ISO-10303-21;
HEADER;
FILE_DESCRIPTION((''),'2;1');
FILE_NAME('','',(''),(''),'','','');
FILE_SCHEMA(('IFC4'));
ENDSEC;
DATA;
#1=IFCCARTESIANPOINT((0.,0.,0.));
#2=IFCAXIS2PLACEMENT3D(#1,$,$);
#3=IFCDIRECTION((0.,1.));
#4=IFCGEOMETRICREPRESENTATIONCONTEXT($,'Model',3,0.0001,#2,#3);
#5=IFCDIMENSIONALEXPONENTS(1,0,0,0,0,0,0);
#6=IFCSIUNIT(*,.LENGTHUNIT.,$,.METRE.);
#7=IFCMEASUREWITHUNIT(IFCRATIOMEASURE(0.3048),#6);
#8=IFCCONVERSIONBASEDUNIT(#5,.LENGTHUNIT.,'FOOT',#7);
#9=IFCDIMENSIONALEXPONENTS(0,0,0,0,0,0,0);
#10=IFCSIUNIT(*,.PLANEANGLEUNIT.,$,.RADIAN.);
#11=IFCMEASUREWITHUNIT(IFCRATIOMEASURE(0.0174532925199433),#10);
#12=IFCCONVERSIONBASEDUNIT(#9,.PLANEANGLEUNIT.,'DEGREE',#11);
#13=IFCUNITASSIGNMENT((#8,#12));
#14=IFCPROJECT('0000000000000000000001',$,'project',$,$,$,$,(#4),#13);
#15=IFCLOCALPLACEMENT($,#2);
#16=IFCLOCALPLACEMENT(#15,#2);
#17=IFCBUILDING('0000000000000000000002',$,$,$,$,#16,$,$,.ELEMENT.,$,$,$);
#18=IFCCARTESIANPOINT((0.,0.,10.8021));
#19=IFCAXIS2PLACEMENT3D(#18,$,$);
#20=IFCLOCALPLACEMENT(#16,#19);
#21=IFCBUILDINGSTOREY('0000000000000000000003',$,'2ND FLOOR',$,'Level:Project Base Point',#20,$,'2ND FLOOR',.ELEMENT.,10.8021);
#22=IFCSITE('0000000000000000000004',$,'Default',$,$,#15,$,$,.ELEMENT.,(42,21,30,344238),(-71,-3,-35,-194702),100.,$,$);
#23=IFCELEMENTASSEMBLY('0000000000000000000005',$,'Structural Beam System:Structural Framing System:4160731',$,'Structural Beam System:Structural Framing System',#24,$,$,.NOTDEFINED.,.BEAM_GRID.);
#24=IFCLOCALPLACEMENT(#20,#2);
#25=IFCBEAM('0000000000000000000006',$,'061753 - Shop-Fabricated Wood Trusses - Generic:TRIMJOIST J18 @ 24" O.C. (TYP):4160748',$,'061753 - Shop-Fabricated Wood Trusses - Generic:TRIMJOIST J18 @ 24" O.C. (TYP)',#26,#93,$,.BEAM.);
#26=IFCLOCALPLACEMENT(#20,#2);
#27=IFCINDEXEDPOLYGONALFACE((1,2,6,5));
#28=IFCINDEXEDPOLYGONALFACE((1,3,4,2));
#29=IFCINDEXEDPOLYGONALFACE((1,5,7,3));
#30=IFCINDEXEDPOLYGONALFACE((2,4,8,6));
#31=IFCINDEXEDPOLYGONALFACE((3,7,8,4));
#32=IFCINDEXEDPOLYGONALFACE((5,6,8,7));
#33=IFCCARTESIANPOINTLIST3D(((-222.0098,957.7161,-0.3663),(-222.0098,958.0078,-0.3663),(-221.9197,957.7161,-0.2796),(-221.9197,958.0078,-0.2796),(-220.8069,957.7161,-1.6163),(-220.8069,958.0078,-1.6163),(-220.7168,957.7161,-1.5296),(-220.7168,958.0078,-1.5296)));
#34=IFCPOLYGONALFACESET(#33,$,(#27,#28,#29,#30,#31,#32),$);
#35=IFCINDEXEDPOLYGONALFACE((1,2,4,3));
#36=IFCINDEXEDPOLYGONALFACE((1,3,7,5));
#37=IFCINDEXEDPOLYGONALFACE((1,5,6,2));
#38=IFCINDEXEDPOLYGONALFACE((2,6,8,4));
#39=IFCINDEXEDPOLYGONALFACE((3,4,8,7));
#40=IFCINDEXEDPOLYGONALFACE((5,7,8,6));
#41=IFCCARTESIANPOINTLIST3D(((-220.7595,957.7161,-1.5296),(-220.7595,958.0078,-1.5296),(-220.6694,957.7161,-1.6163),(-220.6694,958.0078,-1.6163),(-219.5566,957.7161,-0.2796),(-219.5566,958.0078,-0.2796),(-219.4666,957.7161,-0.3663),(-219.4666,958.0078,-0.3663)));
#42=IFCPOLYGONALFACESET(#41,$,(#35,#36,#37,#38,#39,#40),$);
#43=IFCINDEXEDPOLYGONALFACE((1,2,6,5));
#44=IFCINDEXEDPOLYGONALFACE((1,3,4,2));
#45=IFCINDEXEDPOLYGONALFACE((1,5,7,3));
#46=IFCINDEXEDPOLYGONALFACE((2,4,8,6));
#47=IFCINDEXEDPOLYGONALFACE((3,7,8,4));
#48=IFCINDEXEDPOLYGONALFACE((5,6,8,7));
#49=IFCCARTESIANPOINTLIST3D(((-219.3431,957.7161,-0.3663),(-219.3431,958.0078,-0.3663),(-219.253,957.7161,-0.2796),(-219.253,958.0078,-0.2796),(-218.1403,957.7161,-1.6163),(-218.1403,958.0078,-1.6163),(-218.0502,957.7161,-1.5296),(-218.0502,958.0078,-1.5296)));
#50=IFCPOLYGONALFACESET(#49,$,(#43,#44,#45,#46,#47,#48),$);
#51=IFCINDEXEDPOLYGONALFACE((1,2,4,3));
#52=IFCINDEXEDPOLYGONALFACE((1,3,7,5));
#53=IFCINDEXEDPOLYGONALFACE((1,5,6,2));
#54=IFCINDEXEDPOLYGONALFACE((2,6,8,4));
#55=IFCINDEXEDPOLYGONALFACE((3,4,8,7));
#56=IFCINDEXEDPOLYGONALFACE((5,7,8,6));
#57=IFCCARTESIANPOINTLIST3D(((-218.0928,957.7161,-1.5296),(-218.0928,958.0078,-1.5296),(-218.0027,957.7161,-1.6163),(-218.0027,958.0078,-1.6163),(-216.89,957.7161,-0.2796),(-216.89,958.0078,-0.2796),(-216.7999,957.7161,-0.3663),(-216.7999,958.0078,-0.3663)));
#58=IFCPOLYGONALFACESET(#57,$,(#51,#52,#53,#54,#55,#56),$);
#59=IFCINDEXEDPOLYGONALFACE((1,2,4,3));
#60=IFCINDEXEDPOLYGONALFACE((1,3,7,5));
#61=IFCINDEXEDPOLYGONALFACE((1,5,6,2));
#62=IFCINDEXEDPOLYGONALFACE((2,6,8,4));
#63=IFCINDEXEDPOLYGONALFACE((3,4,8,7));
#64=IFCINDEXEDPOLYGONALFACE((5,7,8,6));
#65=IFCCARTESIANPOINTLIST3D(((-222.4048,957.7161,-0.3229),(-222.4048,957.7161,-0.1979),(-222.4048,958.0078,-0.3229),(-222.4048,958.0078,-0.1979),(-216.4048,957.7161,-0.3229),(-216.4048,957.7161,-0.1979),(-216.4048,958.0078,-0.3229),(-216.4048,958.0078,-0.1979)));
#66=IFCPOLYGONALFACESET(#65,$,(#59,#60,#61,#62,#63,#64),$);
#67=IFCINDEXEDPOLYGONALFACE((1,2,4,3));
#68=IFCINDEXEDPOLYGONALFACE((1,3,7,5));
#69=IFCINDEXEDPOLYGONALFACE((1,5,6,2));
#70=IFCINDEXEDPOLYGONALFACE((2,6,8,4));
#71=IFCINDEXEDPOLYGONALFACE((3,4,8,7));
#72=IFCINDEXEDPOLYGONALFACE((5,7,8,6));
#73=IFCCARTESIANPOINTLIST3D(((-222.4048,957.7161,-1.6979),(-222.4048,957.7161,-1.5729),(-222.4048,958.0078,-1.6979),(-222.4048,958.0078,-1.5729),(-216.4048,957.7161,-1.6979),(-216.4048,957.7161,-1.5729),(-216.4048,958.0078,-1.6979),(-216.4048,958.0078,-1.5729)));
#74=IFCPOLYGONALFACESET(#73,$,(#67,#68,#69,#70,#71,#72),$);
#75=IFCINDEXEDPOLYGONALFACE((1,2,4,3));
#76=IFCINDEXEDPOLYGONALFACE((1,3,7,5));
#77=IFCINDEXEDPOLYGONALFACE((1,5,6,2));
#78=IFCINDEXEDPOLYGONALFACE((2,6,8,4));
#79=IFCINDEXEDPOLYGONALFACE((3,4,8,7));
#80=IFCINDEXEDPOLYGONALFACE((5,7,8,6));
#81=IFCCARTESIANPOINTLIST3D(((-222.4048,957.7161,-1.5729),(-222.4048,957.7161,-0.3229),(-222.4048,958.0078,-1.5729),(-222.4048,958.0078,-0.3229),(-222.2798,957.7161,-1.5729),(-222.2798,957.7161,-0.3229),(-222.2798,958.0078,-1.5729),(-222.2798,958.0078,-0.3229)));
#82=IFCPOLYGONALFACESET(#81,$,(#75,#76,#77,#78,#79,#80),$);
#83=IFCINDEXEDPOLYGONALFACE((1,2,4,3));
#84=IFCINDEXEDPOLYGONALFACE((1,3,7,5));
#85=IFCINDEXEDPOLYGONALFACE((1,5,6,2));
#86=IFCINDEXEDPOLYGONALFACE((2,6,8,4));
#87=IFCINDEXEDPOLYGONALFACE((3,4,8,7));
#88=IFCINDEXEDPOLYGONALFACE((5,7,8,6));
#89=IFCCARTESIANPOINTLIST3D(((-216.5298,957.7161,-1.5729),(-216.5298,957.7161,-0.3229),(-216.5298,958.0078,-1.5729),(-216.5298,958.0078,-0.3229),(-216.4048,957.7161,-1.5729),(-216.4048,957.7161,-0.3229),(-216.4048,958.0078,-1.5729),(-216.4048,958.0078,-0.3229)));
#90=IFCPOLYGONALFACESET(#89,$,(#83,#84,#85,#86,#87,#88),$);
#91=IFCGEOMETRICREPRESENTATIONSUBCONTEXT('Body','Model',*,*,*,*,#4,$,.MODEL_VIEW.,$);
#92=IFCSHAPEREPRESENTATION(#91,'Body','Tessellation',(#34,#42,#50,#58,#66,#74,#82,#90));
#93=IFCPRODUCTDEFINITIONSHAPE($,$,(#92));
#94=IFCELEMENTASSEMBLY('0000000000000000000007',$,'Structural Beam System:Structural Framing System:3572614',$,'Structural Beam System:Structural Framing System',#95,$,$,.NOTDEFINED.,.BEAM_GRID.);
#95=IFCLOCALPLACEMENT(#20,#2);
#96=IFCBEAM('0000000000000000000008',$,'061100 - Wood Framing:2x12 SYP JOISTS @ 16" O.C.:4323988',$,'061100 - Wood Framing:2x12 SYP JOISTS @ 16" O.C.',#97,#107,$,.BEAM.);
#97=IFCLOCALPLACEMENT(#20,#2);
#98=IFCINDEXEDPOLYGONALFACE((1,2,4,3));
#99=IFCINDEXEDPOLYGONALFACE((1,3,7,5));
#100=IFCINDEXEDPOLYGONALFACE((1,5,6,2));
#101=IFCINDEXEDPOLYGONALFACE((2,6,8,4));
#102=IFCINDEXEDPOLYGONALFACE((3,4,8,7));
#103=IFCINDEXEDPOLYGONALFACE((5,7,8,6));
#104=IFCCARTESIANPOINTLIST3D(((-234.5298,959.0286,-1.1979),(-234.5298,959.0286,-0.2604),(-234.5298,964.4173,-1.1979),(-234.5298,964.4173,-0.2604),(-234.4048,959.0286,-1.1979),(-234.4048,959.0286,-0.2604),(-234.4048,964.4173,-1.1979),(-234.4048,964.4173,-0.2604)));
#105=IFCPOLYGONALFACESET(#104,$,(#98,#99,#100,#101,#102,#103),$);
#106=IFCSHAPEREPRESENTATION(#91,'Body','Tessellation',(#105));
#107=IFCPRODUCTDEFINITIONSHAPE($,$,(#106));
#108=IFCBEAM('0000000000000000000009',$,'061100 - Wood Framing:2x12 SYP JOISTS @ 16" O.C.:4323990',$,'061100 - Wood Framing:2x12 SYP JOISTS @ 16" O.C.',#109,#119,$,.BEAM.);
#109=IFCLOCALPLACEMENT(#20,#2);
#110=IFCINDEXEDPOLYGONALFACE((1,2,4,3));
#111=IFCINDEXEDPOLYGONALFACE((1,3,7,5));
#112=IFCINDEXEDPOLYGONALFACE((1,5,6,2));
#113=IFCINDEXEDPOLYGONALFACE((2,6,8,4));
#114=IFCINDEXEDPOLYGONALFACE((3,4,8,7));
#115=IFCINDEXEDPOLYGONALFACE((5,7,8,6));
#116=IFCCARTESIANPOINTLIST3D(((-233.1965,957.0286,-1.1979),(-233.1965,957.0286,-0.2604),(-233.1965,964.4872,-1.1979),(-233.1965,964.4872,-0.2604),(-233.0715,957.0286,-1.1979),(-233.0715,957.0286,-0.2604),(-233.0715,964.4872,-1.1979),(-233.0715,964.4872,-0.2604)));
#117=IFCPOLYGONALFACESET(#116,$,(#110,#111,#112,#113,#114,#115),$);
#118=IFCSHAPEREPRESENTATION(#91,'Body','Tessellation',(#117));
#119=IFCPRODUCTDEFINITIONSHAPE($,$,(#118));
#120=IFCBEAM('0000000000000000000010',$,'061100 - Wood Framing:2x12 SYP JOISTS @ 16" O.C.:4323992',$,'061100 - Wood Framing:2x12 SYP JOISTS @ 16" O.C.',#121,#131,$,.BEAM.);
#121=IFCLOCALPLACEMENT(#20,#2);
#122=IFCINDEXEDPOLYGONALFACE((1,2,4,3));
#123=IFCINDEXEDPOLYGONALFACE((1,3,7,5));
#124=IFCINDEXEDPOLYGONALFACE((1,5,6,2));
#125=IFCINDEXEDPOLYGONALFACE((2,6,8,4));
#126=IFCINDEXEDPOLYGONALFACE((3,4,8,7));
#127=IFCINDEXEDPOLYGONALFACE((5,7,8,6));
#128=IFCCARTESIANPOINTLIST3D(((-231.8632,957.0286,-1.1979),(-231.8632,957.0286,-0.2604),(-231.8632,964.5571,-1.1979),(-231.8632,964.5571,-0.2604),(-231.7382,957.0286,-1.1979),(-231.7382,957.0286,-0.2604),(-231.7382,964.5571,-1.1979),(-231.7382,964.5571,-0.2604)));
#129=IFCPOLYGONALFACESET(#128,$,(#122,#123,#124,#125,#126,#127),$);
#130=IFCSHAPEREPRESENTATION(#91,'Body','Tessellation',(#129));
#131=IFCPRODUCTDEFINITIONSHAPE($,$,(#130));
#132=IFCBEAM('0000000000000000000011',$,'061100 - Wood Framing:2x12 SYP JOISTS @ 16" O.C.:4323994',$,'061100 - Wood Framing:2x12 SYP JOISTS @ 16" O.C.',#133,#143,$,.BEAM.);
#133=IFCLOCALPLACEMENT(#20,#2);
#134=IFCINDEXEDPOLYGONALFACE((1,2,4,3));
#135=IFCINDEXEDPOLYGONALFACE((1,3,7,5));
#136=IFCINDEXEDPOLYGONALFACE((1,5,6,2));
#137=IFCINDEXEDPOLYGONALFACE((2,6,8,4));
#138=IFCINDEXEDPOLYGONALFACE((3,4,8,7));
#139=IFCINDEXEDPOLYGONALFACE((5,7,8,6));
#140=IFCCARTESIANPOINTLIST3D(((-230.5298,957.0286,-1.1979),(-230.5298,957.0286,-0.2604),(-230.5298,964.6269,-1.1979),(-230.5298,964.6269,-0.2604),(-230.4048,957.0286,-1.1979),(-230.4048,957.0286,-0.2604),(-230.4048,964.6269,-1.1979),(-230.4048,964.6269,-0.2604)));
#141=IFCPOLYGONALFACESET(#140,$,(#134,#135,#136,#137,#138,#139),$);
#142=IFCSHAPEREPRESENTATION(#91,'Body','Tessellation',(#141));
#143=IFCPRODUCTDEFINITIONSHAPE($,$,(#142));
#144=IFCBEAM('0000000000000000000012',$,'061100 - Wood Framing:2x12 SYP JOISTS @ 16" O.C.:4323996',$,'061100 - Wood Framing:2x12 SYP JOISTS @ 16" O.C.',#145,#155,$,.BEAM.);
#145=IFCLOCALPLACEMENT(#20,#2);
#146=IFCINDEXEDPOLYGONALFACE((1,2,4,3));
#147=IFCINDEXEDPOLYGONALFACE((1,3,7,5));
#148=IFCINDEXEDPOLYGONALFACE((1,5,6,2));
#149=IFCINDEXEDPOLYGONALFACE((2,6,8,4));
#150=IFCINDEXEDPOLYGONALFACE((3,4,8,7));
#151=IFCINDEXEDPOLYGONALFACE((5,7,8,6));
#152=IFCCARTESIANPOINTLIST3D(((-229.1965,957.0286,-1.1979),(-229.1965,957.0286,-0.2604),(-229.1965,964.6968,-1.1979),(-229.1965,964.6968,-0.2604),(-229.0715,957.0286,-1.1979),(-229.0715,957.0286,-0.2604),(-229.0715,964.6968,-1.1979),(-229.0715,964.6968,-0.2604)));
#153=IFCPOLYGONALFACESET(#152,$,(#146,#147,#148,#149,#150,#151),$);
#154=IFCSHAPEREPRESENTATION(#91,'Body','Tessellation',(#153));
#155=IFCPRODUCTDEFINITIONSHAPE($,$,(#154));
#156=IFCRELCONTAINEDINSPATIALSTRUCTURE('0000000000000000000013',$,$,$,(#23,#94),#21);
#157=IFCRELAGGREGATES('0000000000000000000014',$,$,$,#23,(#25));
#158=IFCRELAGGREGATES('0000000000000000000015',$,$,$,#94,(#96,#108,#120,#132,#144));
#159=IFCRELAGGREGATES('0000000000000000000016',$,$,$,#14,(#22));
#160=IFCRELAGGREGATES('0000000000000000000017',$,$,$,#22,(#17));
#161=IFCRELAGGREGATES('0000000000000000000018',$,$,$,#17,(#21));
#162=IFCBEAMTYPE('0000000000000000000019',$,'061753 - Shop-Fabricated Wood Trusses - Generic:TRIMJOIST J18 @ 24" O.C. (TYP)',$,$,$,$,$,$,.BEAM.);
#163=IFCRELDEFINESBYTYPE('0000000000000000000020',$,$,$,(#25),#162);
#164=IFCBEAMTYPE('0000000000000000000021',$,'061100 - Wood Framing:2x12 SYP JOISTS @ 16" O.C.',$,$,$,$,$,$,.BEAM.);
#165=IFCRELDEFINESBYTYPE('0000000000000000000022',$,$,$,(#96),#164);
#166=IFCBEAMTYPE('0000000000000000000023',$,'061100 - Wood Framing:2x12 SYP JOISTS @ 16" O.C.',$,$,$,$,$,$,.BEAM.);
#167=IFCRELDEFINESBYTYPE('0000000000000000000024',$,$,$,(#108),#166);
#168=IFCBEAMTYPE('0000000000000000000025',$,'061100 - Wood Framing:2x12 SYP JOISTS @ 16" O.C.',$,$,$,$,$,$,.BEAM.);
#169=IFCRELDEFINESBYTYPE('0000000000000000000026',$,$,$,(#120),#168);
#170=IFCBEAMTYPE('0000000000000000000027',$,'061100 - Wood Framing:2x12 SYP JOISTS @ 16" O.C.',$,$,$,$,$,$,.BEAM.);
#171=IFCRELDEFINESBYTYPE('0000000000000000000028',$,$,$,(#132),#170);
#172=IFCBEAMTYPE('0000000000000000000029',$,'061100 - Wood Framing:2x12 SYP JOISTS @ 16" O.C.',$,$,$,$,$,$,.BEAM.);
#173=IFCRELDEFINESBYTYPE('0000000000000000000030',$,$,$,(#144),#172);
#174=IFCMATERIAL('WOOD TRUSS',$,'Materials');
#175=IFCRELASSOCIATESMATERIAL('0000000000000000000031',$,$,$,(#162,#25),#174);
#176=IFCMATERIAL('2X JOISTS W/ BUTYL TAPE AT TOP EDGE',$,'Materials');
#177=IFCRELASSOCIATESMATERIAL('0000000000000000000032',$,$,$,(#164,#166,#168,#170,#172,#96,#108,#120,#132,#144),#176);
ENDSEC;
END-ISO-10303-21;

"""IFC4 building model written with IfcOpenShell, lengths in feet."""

from ifc_helpers import new_model, entity, si_unit, converted_unit, direction, frame, frame_2d, origin, origin_2d_with_axis, place, context, subcontext, project, spatial, rectangle, extrude, source, transform, mapped, material, material_profile, profile_set, profile_usage, type_object, type_shapes, element, aggregate, save


model = new_model("IFC4")

# Units and contexts
model_context = context("Model", 3, precision=0.0001, world=origin(), true_north=direction((0.0, 1.0)))
body_context = subcontext(model_context, "Body", "Model", "MODEL_VIEW")
ifc_project = project(units=[converted_unit("LENGTHUNIT", "FOOT", entity("IfcRatioMeasure", 0.3048), si_unit("LENGTHUNIT", "METRE"), dimensions=[1, 0, 0, 0, 0, 0, 0]), converted_unit("PLANEANGLEUNIT", "DEGREE", entity("IfcRatioMeasure", 0.0174532925199433), si_unit("PLANEANGLEUNIT", "RADIAN"), dimensions=[0, 0, 0, 0, 0, 0, 0])], contexts=[model_context])

# Site, building, storey
site_placement = place(None, origin())
site = spatial("IfcSite", under=ifc_project, at=site_placement, Name="Default", CompositionType="ELEMENT", RefLatitude=(42, 21, 30, 344238), RefLongitude=(-71, -3, -35, -194702), RefElevation=100.0)
building_placement = place(site_placement, origin())
building = spatial("IfcBuilding", under=site, at=building_placement, CompositionType="ELEMENT")
storey_placement = place(building_placement, frame((0.0, 0.0, 10.8021)))
storey = spatial("IfcBuildingStorey", under=building, at=storey_placement, Name="2ND FLOOR", ObjectType="Level:Project Base Point", LongName="2ND FLOOR", CompositionType="ELEMENT", Elevation=10.8021)

# Element assemblies, beams
ifc_material_1 = material(Name="WOOD TRUSS", Category="Materials")
ifc_material_profile_1 = material_profile(ifc_material_1, rectangle(XDim=1.7347, YDim=0.125, at=frame_2d((0.0, 0.0), x_axis=(1.0, 0.0))), Name="TRIMJOIST J18 @ 24\" O.C. (TYP)")
ifc_material_profile_2 = material_profile(ifc_material_1, rectangle(XDim=1.7347, YDim=0.125, at=frame_2d((0.0, 0.0), x_axis=(1.0, 0.0))), Name="TRIMJOIST J18 @ 24\" O.C. (TYP)")
ifc_material_profile_3 = material_profile(ifc_material_1, rectangle(XDim=1.7347, YDim=0.125, at=frame_2d((0.0, 0.0), x_axis=(1.0, 0.0))), Name="TRIMJOIST J18 @ 24\" O.C. (TYP)")
ifc_material_profile_4 = material_profile(ifc_material_1, rectangle(XDim=1.7347, YDim=0.125, at=frame_2d((0.0, 0.0), x_axis=(1.0, 0.0))), Name="TRIMJOIST J18 @ 24\" O.C. (TYP)")
ifc_material_profile_5 = material_profile(ifc_material_1, rectangle(XDim=1.7347, YDim=0.125, at=frame_2d((0.0, 0.0), x_axis=(1.0, 0.0))), Name="TRIMJOIST J18 @ 24\" O.C. (TYP)")
ifc_material_profile_6 = material_profile(ifc_material_1, rectangle(XDim=1.7347, YDim=0.125, at=frame_2d((0.0, 0.0), x_axis=(1.0, 0.0))), Name="TRIMJOIST J18 @ 24\" O.C. (TYP)")
ifc_material_profile_7 = material_profile(ifc_material_1, rectangle(XDim=1.7347, YDim=0.125, at=frame_2d((0.0, 0.0), x_axis=(1.0, 0.0))), Name="TRIMJOIST J18 @ 24\" O.C. (TYP)")
ifc_material_profile_8 = material_profile(ifc_material_1, rectangle(XDim=1.7347, YDim=0.125, at=frame_2d((0.0, 0.0), x_axis=(1.0, 0.0))), Name="TRIMJOIST J18 @ 24\" O.C. (TYP)")
ifc_material_profile_9 = material_profile(ifc_material_1, rectangle(XDim=1.7347, YDim=0.125, at=frame_2d((0.0, 0.0), x_axis=(1.0, 0.0))), Name="TRIMJOIST J18 @ 24\" O.C. (TYP)")
ifc_material_profile_10 = material_profile(ifc_material_1, rectangle(XDim=1.7347, YDim=0.125, at=origin_2d_with_axis()), Name="TRIMJOIST J18 @ 24\" O.C. (TYP)")
ifc_material_profile_11 = material_profile(ifc_material_1, rectangle(XDim=0.125, YDim=0.2917, at=origin_2d_with_axis()), Name="TRIMJOIST J18 @ 24\" O.C. (TYP)")
ifc_material_profile_12 = material_profile(ifc_material_1, rectangle(XDim=0.125, YDim=0.2917, at=origin_2d_with_axis()), Name="TRIMJOIST J18 @ 24\" O.C. (TYP)")
ifc_material_profile_13 = material_profile(ifc_material_1, rectangle(XDim=1.25, YDim=0.2917, at=origin_2d_with_axis()), Name="TRIMJOIST J18 @ 24\" O.C. (TYP)")
ifc_material_profile_14 = material_profile(ifc_material_1, rectangle(XDim=1.25, YDim=0.2917, at=origin_2d_with_axis()), Name="TRIMJOIST J18 @ 24\" O.C. (TYP)")
ifc_profile_set_1 = profile_set([ifc_material_profile_1, ifc_material_profile_2, ifc_material_profile_3, ifc_material_profile_4, ifc_material_profile_5, ifc_material_profile_6, ifc_material_profile_7, ifc_material_profile_8, ifc_material_profile_9, ifc_material_profile_10, ifc_material_profile_11, ifc_material_profile_12, ifc_material_profile_13, ifc_material_profile_14], Name="TRIMJOIST J18 @ 24\" O.C. (TYP)")
assembly_1_placement = place(storey_placement, origin())
assembly_1 = element("IfcElementAssembly", 1, at=assembly_1_placement, inside=storey, Name="Structural Beam System:Structural Framing System:4160731", ObjectType="Structural Beam System:Structural Framing System", AssemblyPlace="NOTDEFINED", PredefinedType="BEAM_GRID")
ifc_profile_usage_1 = profile_usage(ifc_profile_set_1, cardinal=8)
beam_type_1 = type_object("IfcBeamType", Name="061753 - Shop-Fabricated Wood Trusses - Generic:TRIMJOIST J18 @ 24\" O.C. (TYP)", PredefinedType="BEAM", material=ifc_profile_set_1)
shared_shape_1 = source(origin(), body_context, "Body", "SweptSolid", [
    extrude(rectangle(XDim=1.7347, YDim=0.125, at=frame_2d((0.0, 0.0), x_axis=(1.0, 0.0))), frame((1.9585, -0.1458, 0.0), z_axis=(0.0, 1.0, 0.0), x_axis=(0.693383, 0.0, 0.720569)), (0.0, 0.0, 1.0), 0.2917),
    extrude(rectangle(XDim=1.7347, YDim=0.125, at=frame_2d((0.0, 0.0), x_axis=(1.0, 0.0))), frame((0.7082, -0.1458, 0.0), z_axis=(0.0, 1.0, 0.0), x_axis=(0.693383, 0.0, -0.720569)), (0.0, 0.0, 1.0), 0.2917),
    extrude(rectangle(XDim=1.7347, YDim=0.125, at=frame_2d((0.0, 0.0), x_axis=(1.0, 0.0))), frame((-0.7082, -0.1458, 0.0), z_axis=(0.0, 1.0, 0.0), x_axis=(0.693383, 0.0, 0.720569)), (0.0, 0.0, 1.0), 0.2917),
    extrude(rectangle(XDim=1.7347, YDim=0.125, at=frame_2d((0.0, 0.0), x_axis=(1.0, 0.0))), frame((-1.9585, -0.1458, 0.0), z_axis=(0.0, 1.0, 0.0), x_axis=(0.693383, 0.0, -0.720569)), (0.0, 0.0, 1.0), 0.2917),
    extrude(rectangle(XDim=0.125, YDim=0.2917, at=origin_2d_with_axis()), frame((-3.0, 0.0, 0.6875), z_axis=(1.0, 0.0, 0.0), x_axis=(0.0, 0.0, -1.0)), (0.0, 0.0, 1.0), 6.0),
    extrude(rectangle(XDim=0.125, YDim=0.2917, at=origin_2d_with_axis()), frame((-3.0, 0.0, -0.6875), z_axis=(1.0, 0.0, 0.0), x_axis=(0.0, 0.0, -1.0)), (0.0, 0.0, 1.0), 6.0),
    extrude(rectangle(XDim=1.25, YDim=0.2917, at=origin_2d_with_axis()), frame((2.875, 0.0, 0.0), z_axis=(1.0, 0.0, 0.0), x_axis=(0.0, 0.0, -1.0)), (0.0, 0.0, 1.0), 0.125),
    extrude(rectangle(XDim=1.25, YDim=0.2917, at=origin_2d_with_axis()), frame((-3.0, 0.0, 0.0), z_axis=(1.0, 0.0, 0.0), x_axis=(0.0, 0.0, -1.0)), (0.0, 0.0, 1.0), 0.125),
])
type_shapes(beam_type_1, [shared_shape_1])
beam_1_placement = place(assembly_1_placement, frame((-219.4048, 957.8619, -0.9479), z_axis=(0.0, 0.0, 1.0), x_axis=(-1.0, 0.0, 0.0)))
beam_1 = element("IfcBeam", 2, at=beam_1_placement, type_object=beam_type_1, material=ifc_profile_usage_1, Name="061753 - Shop-Fabricated Wood Trusses - Generic:TRIMJOIST J18 @ 24\" O.C. (TYP):4160748", ObjectType="061753 - Shop-Fabricated Wood Trusses - Generic:TRIMJOIST J18 @ 24\" O.C. (TYP)", PredefinedType="BEAM", context=body_context, shape_type="MappedRepresentation", body=[
    mapped(shared_shape_1, transform((0.0, 0.0, 0.0), scale=1.0)),
])
aggregate(assembly_1, [beam_1])
assembly_2_placement = place(storey_placement, origin())
assembly_2 = element("IfcElementAssembly", 3, at=assembly_2_placement, inside=storey, Name="Structural Beam System:Structural Framing System:3572614", ObjectType="Structural Beam System:Structural Framing System", AssemblyPlace="NOTDEFINED", PredefinedType="BEAM_GRID")
ifc_material_2 = material(Name="2X JOISTS W/ BUTYL TAPE AT TOP EDGE", Category="Materials")
ifc_material_profile_15 = material_profile(ifc_material_2, rectangle(XDim=0.9375, YDim=0.125, at=origin_2d_with_axis()), Name="2x12 SYP JOISTS @ 16\" O.C.")
ifc_profile_set_2 = profile_set([ifc_material_profile_15], Name="2x12 SYP JOISTS @ 16\" O.C.")
ifc_profile_usage_2 = profile_usage(ifc_profile_set_2, cardinal=8)
beam_type_2 = type_object("IfcBeamType", Name="061100 - Wood Framing:2x12 SYP JOISTS @ 16\" O.C.", PredefinedType="BEAM", material=ifc_profile_set_2)
shared_shape_2 = source(origin(), body_context, "Body", "SweptSolid", [
    extrude(rectangle(XDim=0.9375, YDim=0.125, at=origin_2d_with_axis()), frame((-2.6944, 0.0, 0.0), z_axis=(1.0, 0.0, 0.0), x_axis=(0.0, 0.0, -1.0)), (0.0, 0.0, 1.0), 5.3887),
])
type_shapes(beam_type_2, [shared_shape_2])
beam_2_placement = place(assembly_2_placement, frame((-234.4673, 961.723, -0.7292), z_axis=(0.0, 0.0, 1.0), x_axis=(0.0, 1.0, 0.0)))
beam_2 = element("IfcBeam", 4, at=beam_2_placement, type_object=beam_type_2, material=ifc_profile_usage_2, Name="061100 - Wood Framing:2x12 SYP JOISTS @ 16\" O.C.:4323988", ObjectType="061100 - Wood Framing:2x12 SYP JOISTS @ 16\" O.C.", PredefinedType="BEAM", context=body_context, shape_type="MappedRepresentation", body=[
    mapped(shared_shape_2, transform((0.0, 0.0, 0.0), scale=1.0)),
])
ifc_profile_usage_3 = profile_usage(ifc_profile_set_2, cardinal=8)
beam_type_3 = type_object("IfcBeamType", Name="061100 - Wood Framing:2x12 SYP JOISTS @ 16\" O.C.", PredefinedType="BEAM", material=ifc_profile_set_2)
shared_shape_3 = source(origin(), body_context, "Body", "SweptSolid", [
    extrude(rectangle(XDim=0.9375, YDim=0.125, at=origin_2d_with_axis()), frame((-3.7293, 0.0, 0.0), z_axis=(1.0, 0.0, 0.0), x_axis=(0.0, 0.0, -1.0)), (0.0, 0.0, 1.0), 7.4586),
])
type_shapes(beam_type_3, [shared_shape_3])
beam_3_placement = place(assembly_2_placement, frame((-233.134, 960.7579, -0.7292), z_axis=(0.0, 0.0, 1.0), x_axis=(0.0, 1.0, 0.0)))
beam_3 = element("IfcBeam", 5, at=beam_3_placement, type_object=beam_type_3, material=ifc_profile_usage_3, Name="061100 - Wood Framing:2x12 SYP JOISTS @ 16\" O.C.:4323990", ObjectType="061100 - Wood Framing:2x12 SYP JOISTS @ 16\" O.C.", PredefinedType="BEAM", context=body_context, shape_type="MappedRepresentation", body=[
    mapped(shared_shape_3, transform((0.0, 0.0, 0.0), scale=1.0)),
])
ifc_profile_usage_4 = profile_usage(ifc_profile_set_2, cardinal=8)
beam_type_4 = type_object("IfcBeamType", Name="061100 - Wood Framing:2x12 SYP JOISTS @ 16\" O.C.", PredefinedType="BEAM", material=ifc_profile_set_2)
shared_shape_4 = source(origin(), body_context, "Body", "SweptSolid", [
    extrude(rectangle(XDim=0.9375, YDim=0.125, at=origin_2d_with_axis()), frame((-3.7642, 0.0, 0.0), z_axis=(1.0, 0.0, 0.0), x_axis=(0.0, 0.0, -1.0)), (0.0, 0.0, 1.0), 7.5285),
])
type_shapes(beam_type_4, [shared_shape_4])
beam_4_placement = place(assembly_2_placement, frame((-231.8007, 960.7928, -0.7292), z_axis=(0.0, 0.0, 1.0), x_axis=(0.0, 1.0, 0.0)))
beam_4 = element("IfcBeam", 6, at=beam_4_placement, type_object=beam_type_4, material=ifc_profile_usage_4, Name="061100 - Wood Framing:2x12 SYP JOISTS @ 16\" O.C.:4323992", ObjectType="061100 - Wood Framing:2x12 SYP JOISTS @ 16\" O.C.", PredefinedType="BEAM", context=body_context, shape_type="MappedRepresentation", body=[
    mapped(shared_shape_4, transform((0.0, 0.0, 0.0), scale=1.0)),
])
ifc_profile_usage_5 = profile_usage(ifc_profile_set_2, cardinal=8)
beam_type_5 = type_object("IfcBeamType", Name="061100 - Wood Framing:2x12 SYP JOISTS @ 16\" O.C.", PredefinedType="BEAM", material=ifc_profile_set_2)
shared_shape_5 = source(origin(), body_context, "Body", "SweptSolid", [
    extrude(rectangle(XDim=0.9375, YDim=0.125, at=origin_2d_with_axis()), frame((-3.7992, 0.0, 0.0), z_axis=(1.0, 0.0, 0.0), x_axis=(0.0, 0.0, -1.0)), (0.0, 0.0, 1.0), 7.5983),
])
type_shapes(beam_type_5, [shared_shape_5])
beam_5_placement = place(assembly_2_placement, frame((-230.4673, 960.8278, -0.7292), z_axis=(0.0, 0.0, 1.0), x_axis=(0.0, 1.0, 0.0)))
beam_5 = element("IfcBeam", 7, at=beam_5_placement, type_object=beam_type_5, material=ifc_profile_usage_5, Name="061100 - Wood Framing:2x12 SYP JOISTS @ 16\" O.C.:4323994", ObjectType="061100 - Wood Framing:2x12 SYP JOISTS @ 16\" O.C.", PredefinedType="BEAM", context=body_context, shape_type="MappedRepresentation", body=[
    mapped(shared_shape_5, transform((0.0, 0.0, 0.0), scale=1.0)),
])
ifc_profile_usage_6 = profile_usage(ifc_profile_set_2, cardinal=8)
beam_type_6 = type_object("IfcBeamType", Name="061100 - Wood Framing:2x12 SYP JOISTS @ 16\" O.C.", PredefinedType="BEAM", material=ifc_profile_set_2)
shared_shape_6 = source(origin(), body_context, "Body", "SweptSolid", [
    extrude(rectangle(XDim=0.9375, YDim=0.125, at=origin_2d_with_axis()), frame((-3.8341, 0.0, 0.0), z_axis=(1.0, 0.0, 0.0), x_axis=(0.0, 0.0, -1.0)), (0.0, 0.0, 1.0), 7.6682),
])
type_shapes(beam_type_6, [shared_shape_6])
beam_6_placement = place(assembly_2_placement, frame((-229.134, 960.8627, -0.7292), z_axis=(0.0, 0.0, 1.0), x_axis=(0.0, 1.0, 0.0)))
beam_6 = element("IfcBeam", 8, at=beam_6_placement, type_object=beam_type_6, material=ifc_profile_usage_6, Name="061100 - Wood Framing:2x12 SYP JOISTS @ 16\" O.C.:4323996", ObjectType="061100 - Wood Framing:2x12 SYP JOISTS @ 16\" O.C.", PredefinedType="BEAM", context=body_context, shape_type="MappedRepresentation", body=[
    mapped(shared_shape_6, transform((0.0, 0.0, 0.0), scale=1.0)),
])
aggregate(assembly_2, [beam_2, beam_3, beam_4, beam_5, beam_6])

save(model, "model.ifc")
